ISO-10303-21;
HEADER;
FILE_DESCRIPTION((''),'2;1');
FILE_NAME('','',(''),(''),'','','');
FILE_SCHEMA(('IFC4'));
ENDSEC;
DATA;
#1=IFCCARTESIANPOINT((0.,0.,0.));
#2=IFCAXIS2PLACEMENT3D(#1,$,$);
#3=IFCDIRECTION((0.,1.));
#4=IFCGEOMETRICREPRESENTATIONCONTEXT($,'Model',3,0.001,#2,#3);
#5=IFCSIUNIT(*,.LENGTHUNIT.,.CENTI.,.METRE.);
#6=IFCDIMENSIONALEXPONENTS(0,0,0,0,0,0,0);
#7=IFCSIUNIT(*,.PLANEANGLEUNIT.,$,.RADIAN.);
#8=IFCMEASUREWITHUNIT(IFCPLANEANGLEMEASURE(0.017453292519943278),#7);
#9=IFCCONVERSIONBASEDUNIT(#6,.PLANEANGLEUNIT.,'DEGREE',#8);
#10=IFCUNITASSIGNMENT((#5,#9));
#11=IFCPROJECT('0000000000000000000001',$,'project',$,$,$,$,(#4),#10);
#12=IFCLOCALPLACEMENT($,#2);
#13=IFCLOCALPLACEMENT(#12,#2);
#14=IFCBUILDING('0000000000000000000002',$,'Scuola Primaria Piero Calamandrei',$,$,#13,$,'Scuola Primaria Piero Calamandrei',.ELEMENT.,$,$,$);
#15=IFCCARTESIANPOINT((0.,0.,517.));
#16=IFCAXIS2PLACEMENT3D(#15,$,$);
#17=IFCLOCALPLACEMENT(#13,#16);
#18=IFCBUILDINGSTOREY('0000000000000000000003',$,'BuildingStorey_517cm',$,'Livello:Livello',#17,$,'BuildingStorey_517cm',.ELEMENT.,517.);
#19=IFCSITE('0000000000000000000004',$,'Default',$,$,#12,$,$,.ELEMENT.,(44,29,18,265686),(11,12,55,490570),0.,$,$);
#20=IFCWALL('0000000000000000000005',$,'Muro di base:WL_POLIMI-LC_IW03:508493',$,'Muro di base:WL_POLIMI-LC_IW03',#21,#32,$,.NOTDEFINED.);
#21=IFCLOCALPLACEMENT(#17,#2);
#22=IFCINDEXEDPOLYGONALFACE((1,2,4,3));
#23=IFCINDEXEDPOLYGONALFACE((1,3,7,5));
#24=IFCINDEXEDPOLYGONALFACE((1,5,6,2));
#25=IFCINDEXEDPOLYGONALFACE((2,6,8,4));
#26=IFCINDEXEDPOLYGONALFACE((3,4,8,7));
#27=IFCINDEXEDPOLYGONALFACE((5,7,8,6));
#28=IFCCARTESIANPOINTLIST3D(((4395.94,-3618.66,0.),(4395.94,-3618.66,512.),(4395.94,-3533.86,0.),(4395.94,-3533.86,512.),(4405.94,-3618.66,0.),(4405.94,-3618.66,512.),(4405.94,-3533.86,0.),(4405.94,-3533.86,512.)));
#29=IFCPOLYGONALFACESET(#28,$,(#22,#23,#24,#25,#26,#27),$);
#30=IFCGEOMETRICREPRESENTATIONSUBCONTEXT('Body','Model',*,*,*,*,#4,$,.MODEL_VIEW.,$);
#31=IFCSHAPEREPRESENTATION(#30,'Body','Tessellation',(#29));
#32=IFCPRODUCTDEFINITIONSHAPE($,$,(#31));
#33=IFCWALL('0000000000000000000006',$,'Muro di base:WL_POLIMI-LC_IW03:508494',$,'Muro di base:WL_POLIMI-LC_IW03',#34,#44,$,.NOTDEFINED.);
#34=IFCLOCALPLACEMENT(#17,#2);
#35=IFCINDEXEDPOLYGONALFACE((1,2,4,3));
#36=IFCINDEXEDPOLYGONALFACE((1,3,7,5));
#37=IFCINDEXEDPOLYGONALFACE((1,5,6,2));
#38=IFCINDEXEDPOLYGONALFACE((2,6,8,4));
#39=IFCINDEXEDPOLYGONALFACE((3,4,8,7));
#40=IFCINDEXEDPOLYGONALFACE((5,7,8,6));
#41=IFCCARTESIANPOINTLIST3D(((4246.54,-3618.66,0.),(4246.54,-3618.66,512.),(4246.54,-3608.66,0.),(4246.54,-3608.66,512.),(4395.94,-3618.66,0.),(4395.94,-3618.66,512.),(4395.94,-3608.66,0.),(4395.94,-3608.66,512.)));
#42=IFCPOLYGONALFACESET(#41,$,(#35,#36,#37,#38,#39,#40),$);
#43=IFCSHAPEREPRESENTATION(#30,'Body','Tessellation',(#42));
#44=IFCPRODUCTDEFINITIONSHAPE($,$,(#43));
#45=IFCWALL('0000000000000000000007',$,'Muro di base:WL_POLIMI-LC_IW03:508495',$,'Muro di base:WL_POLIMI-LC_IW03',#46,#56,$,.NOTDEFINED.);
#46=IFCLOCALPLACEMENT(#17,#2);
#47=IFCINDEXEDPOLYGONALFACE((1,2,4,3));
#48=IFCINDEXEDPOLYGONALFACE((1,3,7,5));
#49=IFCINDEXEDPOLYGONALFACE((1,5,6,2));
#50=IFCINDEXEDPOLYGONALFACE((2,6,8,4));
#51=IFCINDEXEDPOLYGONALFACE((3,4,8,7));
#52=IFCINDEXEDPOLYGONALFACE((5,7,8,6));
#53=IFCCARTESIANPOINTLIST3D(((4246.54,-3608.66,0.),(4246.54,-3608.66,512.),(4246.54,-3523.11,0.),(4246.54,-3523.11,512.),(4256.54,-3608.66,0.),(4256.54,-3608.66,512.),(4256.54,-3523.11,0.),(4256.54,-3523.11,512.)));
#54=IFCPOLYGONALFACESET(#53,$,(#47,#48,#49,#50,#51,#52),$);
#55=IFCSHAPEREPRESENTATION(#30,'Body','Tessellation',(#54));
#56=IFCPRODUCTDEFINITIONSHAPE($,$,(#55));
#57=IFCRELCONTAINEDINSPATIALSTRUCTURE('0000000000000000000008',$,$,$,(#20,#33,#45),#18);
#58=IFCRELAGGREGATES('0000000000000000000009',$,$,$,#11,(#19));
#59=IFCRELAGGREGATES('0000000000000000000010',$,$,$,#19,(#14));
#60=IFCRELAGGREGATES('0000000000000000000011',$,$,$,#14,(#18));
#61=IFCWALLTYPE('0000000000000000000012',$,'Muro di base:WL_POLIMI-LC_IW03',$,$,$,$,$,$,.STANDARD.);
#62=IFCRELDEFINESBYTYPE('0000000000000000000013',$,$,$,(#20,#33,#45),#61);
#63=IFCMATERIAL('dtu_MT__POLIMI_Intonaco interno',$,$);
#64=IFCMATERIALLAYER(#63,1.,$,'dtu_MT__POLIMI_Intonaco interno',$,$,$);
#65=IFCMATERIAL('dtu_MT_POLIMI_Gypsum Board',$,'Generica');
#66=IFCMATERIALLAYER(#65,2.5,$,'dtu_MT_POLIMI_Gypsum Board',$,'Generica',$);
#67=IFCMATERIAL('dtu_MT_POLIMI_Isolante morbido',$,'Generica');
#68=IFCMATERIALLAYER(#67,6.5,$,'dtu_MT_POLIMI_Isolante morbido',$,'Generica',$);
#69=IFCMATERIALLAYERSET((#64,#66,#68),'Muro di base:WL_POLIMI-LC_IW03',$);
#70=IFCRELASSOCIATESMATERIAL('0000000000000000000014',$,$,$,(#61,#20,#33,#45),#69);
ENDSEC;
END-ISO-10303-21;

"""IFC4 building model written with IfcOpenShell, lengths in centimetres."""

from ifc_helpers import new_model, entity, si_unit, converted_unit, direction, frame, frame_2d, origin, place, context, subcontext, project, spatial, rectangle, extrude, material, layer, layer_set, layer_usage, type_object, element, save


model = new_model("IFC4")

# Units and contexts
model_context = context("Model", 3, precision=0.001, world=origin(), true_north=direction((0.0, 1.0)))
body_context = subcontext(model_context, "Body", "Model", "MODEL_VIEW")
ifc_project = project(units=[si_unit("LENGTHUNIT", "METRE", prefix="CENTI"), converted_unit("PLANEANGLEUNIT", "DEGREE", entity("IfcPlaneAngleMeasure", 0.017453292519943278), si_unit("PLANEANGLEUNIT", "RADIAN"), dimensions=[0, 0, 0, 0, 0, 0, 0])], contexts=[model_context])

# Site, building, storey
site_placement = place(None, origin())
site = spatial("IfcSite", under=ifc_project, at=site_placement, Name="Default", CompositionType="ELEMENT", RefLatitude=(44, 29, 18, 265686), RefLongitude=(11, 12, 55, 490570), RefElevation=0.0)
building_placement = place(site_placement, origin())
building = spatial("IfcBuilding", under=site, at=building_placement, Name="Scuola Primaria Piero Calamandrei", LongName="Scuola Primaria Piero Calamandrei", CompositionType="ELEMENT")
storey_placement = place(building_placement, frame((0.0, 0.0, 517.0)))
storey = spatial("IfcBuildingStorey", under=building, at=storey_placement, Name="BuildingStorey_517cm", ObjectType="Livello:Livello", LongName="BuildingStorey_517cm", CompositionType="ELEMENT", Elevation=517.0)

# Shared definitions
ifc_material_1 = material(Name="dtu_MT_POLIMI_Isolante morbido", Category="Generica")
ifc_material_2 = material(Name="dtu_MT_POLIMI_Gypsum Board", Category="Generica")
ifc_material_3 = material(Name="dtu_MT__POLIMI_Intonaco interno")

# Walls
ifc_layer_1 = layer(ifc_material_3, 1.0, Name="dtu_MT__POLIMI_Intonaco interno")
ifc_layer_2 = layer(ifc_material_2, 2.5, Name="dtu_MT_POLIMI_Gypsum Board", Category="Generica")
ifc_layer_3 = layer(ifc_material_1, 6.5, Name="dtu_MT_POLIMI_Isolante morbido", Category="Generica")
ifc_layer_set_1 = layer_set([ifc_layer_1, ifc_layer_2, ifc_layer_3], Name="Muro di base:WL_POLIMI-LC_IW03")
wall_type_1 = type_object("IfcWallType", Name="Muro di base:WL_POLIMI-LC_IW03", PredefinedType="STANDARD", material=ifc_layer_set_1)
ifc_layer_usage_1 = layer_usage(ifc_layer_set_1, "AXIS2", "NEGATIVE", 5.0)
wall_1_placement = place(storey_placement, frame((4400.94, -3618.66, 0.0), z_axis=(0.0, 0.0, 1.0), x_axis=(0.0, 1.0, 0.0)))
element("IfcWall", 1, at=wall_1_placement, inside=storey, type_object=wall_type_1, material=ifc_layer_usage_1, Name="Muro di base:WL_POLIMI-LC_IW03:508493", ObjectType="Muro di base:WL_POLIMI-LC_IW03", PredefinedType="NOTDEFINED", context=body_context, shape_type="SweptSolid", body=[
    extrude(rectangle(XDim=84.8, YDim=10.0, at=frame_2d((42.4, 0.0), x_axis=(-1.0, 0.0))), origin(), (0.0, 0.0, 1.0), 512.0),
])
ifc_layer_usage_2 = layer_usage(ifc_layer_set_1, "AXIS2", "NEGATIVE", 5.0)
wall_2_placement = place(storey_placement, frame((4246.54, -3613.66, 0.0)))
element("IfcWall", 2, at=wall_2_placement, inside=storey, type_object=wall_type_1, material=ifc_layer_usage_2, Name="Muro di base:WL_POLIMI-LC_IW03:508494", ObjectType="Muro di base:WL_POLIMI-LC_IW03", PredefinedType="NOTDEFINED", context=body_context, shape_type="SweptSolid", body=[
    extrude(rectangle(XDim=149.39, YDim=10.0, at=frame_2d((74.7, 0.0), x_axis=(-1.0, 0.0))), origin(), (0.0, 0.0, 1.0), 512.0),
])
ifc_layer_usage_3 = layer_usage(ifc_layer_set_1, "AXIS2", "NEGATIVE", 5.0)
wall_3_placement = place(storey_placement, frame((4251.54, -3523.11, 0.0), z_axis=(0.0, 0.0, 1.0), x_axis=(0.0, -1.0, 0.0)))
element("IfcWall", 3, at=wall_3_placement, inside=storey, type_object=wall_type_1, material=ifc_layer_usage_3, Name="Muro di base:WL_POLIMI-LC_IW03:508495", ObjectType="Muro di base:WL_POLIMI-LC_IW03", PredefinedType="NOTDEFINED", context=body_context, shape_type="SweptSolid", body=[
    extrude(rectangle(XDim=85.55, YDim=10.0, at=frame_2d((42.78, 0.0), x_axis=(-1.0, 0.0))), origin(), (0.0, 0.0, 1.0), 512.0),
])

save(model, "model.ifc")
